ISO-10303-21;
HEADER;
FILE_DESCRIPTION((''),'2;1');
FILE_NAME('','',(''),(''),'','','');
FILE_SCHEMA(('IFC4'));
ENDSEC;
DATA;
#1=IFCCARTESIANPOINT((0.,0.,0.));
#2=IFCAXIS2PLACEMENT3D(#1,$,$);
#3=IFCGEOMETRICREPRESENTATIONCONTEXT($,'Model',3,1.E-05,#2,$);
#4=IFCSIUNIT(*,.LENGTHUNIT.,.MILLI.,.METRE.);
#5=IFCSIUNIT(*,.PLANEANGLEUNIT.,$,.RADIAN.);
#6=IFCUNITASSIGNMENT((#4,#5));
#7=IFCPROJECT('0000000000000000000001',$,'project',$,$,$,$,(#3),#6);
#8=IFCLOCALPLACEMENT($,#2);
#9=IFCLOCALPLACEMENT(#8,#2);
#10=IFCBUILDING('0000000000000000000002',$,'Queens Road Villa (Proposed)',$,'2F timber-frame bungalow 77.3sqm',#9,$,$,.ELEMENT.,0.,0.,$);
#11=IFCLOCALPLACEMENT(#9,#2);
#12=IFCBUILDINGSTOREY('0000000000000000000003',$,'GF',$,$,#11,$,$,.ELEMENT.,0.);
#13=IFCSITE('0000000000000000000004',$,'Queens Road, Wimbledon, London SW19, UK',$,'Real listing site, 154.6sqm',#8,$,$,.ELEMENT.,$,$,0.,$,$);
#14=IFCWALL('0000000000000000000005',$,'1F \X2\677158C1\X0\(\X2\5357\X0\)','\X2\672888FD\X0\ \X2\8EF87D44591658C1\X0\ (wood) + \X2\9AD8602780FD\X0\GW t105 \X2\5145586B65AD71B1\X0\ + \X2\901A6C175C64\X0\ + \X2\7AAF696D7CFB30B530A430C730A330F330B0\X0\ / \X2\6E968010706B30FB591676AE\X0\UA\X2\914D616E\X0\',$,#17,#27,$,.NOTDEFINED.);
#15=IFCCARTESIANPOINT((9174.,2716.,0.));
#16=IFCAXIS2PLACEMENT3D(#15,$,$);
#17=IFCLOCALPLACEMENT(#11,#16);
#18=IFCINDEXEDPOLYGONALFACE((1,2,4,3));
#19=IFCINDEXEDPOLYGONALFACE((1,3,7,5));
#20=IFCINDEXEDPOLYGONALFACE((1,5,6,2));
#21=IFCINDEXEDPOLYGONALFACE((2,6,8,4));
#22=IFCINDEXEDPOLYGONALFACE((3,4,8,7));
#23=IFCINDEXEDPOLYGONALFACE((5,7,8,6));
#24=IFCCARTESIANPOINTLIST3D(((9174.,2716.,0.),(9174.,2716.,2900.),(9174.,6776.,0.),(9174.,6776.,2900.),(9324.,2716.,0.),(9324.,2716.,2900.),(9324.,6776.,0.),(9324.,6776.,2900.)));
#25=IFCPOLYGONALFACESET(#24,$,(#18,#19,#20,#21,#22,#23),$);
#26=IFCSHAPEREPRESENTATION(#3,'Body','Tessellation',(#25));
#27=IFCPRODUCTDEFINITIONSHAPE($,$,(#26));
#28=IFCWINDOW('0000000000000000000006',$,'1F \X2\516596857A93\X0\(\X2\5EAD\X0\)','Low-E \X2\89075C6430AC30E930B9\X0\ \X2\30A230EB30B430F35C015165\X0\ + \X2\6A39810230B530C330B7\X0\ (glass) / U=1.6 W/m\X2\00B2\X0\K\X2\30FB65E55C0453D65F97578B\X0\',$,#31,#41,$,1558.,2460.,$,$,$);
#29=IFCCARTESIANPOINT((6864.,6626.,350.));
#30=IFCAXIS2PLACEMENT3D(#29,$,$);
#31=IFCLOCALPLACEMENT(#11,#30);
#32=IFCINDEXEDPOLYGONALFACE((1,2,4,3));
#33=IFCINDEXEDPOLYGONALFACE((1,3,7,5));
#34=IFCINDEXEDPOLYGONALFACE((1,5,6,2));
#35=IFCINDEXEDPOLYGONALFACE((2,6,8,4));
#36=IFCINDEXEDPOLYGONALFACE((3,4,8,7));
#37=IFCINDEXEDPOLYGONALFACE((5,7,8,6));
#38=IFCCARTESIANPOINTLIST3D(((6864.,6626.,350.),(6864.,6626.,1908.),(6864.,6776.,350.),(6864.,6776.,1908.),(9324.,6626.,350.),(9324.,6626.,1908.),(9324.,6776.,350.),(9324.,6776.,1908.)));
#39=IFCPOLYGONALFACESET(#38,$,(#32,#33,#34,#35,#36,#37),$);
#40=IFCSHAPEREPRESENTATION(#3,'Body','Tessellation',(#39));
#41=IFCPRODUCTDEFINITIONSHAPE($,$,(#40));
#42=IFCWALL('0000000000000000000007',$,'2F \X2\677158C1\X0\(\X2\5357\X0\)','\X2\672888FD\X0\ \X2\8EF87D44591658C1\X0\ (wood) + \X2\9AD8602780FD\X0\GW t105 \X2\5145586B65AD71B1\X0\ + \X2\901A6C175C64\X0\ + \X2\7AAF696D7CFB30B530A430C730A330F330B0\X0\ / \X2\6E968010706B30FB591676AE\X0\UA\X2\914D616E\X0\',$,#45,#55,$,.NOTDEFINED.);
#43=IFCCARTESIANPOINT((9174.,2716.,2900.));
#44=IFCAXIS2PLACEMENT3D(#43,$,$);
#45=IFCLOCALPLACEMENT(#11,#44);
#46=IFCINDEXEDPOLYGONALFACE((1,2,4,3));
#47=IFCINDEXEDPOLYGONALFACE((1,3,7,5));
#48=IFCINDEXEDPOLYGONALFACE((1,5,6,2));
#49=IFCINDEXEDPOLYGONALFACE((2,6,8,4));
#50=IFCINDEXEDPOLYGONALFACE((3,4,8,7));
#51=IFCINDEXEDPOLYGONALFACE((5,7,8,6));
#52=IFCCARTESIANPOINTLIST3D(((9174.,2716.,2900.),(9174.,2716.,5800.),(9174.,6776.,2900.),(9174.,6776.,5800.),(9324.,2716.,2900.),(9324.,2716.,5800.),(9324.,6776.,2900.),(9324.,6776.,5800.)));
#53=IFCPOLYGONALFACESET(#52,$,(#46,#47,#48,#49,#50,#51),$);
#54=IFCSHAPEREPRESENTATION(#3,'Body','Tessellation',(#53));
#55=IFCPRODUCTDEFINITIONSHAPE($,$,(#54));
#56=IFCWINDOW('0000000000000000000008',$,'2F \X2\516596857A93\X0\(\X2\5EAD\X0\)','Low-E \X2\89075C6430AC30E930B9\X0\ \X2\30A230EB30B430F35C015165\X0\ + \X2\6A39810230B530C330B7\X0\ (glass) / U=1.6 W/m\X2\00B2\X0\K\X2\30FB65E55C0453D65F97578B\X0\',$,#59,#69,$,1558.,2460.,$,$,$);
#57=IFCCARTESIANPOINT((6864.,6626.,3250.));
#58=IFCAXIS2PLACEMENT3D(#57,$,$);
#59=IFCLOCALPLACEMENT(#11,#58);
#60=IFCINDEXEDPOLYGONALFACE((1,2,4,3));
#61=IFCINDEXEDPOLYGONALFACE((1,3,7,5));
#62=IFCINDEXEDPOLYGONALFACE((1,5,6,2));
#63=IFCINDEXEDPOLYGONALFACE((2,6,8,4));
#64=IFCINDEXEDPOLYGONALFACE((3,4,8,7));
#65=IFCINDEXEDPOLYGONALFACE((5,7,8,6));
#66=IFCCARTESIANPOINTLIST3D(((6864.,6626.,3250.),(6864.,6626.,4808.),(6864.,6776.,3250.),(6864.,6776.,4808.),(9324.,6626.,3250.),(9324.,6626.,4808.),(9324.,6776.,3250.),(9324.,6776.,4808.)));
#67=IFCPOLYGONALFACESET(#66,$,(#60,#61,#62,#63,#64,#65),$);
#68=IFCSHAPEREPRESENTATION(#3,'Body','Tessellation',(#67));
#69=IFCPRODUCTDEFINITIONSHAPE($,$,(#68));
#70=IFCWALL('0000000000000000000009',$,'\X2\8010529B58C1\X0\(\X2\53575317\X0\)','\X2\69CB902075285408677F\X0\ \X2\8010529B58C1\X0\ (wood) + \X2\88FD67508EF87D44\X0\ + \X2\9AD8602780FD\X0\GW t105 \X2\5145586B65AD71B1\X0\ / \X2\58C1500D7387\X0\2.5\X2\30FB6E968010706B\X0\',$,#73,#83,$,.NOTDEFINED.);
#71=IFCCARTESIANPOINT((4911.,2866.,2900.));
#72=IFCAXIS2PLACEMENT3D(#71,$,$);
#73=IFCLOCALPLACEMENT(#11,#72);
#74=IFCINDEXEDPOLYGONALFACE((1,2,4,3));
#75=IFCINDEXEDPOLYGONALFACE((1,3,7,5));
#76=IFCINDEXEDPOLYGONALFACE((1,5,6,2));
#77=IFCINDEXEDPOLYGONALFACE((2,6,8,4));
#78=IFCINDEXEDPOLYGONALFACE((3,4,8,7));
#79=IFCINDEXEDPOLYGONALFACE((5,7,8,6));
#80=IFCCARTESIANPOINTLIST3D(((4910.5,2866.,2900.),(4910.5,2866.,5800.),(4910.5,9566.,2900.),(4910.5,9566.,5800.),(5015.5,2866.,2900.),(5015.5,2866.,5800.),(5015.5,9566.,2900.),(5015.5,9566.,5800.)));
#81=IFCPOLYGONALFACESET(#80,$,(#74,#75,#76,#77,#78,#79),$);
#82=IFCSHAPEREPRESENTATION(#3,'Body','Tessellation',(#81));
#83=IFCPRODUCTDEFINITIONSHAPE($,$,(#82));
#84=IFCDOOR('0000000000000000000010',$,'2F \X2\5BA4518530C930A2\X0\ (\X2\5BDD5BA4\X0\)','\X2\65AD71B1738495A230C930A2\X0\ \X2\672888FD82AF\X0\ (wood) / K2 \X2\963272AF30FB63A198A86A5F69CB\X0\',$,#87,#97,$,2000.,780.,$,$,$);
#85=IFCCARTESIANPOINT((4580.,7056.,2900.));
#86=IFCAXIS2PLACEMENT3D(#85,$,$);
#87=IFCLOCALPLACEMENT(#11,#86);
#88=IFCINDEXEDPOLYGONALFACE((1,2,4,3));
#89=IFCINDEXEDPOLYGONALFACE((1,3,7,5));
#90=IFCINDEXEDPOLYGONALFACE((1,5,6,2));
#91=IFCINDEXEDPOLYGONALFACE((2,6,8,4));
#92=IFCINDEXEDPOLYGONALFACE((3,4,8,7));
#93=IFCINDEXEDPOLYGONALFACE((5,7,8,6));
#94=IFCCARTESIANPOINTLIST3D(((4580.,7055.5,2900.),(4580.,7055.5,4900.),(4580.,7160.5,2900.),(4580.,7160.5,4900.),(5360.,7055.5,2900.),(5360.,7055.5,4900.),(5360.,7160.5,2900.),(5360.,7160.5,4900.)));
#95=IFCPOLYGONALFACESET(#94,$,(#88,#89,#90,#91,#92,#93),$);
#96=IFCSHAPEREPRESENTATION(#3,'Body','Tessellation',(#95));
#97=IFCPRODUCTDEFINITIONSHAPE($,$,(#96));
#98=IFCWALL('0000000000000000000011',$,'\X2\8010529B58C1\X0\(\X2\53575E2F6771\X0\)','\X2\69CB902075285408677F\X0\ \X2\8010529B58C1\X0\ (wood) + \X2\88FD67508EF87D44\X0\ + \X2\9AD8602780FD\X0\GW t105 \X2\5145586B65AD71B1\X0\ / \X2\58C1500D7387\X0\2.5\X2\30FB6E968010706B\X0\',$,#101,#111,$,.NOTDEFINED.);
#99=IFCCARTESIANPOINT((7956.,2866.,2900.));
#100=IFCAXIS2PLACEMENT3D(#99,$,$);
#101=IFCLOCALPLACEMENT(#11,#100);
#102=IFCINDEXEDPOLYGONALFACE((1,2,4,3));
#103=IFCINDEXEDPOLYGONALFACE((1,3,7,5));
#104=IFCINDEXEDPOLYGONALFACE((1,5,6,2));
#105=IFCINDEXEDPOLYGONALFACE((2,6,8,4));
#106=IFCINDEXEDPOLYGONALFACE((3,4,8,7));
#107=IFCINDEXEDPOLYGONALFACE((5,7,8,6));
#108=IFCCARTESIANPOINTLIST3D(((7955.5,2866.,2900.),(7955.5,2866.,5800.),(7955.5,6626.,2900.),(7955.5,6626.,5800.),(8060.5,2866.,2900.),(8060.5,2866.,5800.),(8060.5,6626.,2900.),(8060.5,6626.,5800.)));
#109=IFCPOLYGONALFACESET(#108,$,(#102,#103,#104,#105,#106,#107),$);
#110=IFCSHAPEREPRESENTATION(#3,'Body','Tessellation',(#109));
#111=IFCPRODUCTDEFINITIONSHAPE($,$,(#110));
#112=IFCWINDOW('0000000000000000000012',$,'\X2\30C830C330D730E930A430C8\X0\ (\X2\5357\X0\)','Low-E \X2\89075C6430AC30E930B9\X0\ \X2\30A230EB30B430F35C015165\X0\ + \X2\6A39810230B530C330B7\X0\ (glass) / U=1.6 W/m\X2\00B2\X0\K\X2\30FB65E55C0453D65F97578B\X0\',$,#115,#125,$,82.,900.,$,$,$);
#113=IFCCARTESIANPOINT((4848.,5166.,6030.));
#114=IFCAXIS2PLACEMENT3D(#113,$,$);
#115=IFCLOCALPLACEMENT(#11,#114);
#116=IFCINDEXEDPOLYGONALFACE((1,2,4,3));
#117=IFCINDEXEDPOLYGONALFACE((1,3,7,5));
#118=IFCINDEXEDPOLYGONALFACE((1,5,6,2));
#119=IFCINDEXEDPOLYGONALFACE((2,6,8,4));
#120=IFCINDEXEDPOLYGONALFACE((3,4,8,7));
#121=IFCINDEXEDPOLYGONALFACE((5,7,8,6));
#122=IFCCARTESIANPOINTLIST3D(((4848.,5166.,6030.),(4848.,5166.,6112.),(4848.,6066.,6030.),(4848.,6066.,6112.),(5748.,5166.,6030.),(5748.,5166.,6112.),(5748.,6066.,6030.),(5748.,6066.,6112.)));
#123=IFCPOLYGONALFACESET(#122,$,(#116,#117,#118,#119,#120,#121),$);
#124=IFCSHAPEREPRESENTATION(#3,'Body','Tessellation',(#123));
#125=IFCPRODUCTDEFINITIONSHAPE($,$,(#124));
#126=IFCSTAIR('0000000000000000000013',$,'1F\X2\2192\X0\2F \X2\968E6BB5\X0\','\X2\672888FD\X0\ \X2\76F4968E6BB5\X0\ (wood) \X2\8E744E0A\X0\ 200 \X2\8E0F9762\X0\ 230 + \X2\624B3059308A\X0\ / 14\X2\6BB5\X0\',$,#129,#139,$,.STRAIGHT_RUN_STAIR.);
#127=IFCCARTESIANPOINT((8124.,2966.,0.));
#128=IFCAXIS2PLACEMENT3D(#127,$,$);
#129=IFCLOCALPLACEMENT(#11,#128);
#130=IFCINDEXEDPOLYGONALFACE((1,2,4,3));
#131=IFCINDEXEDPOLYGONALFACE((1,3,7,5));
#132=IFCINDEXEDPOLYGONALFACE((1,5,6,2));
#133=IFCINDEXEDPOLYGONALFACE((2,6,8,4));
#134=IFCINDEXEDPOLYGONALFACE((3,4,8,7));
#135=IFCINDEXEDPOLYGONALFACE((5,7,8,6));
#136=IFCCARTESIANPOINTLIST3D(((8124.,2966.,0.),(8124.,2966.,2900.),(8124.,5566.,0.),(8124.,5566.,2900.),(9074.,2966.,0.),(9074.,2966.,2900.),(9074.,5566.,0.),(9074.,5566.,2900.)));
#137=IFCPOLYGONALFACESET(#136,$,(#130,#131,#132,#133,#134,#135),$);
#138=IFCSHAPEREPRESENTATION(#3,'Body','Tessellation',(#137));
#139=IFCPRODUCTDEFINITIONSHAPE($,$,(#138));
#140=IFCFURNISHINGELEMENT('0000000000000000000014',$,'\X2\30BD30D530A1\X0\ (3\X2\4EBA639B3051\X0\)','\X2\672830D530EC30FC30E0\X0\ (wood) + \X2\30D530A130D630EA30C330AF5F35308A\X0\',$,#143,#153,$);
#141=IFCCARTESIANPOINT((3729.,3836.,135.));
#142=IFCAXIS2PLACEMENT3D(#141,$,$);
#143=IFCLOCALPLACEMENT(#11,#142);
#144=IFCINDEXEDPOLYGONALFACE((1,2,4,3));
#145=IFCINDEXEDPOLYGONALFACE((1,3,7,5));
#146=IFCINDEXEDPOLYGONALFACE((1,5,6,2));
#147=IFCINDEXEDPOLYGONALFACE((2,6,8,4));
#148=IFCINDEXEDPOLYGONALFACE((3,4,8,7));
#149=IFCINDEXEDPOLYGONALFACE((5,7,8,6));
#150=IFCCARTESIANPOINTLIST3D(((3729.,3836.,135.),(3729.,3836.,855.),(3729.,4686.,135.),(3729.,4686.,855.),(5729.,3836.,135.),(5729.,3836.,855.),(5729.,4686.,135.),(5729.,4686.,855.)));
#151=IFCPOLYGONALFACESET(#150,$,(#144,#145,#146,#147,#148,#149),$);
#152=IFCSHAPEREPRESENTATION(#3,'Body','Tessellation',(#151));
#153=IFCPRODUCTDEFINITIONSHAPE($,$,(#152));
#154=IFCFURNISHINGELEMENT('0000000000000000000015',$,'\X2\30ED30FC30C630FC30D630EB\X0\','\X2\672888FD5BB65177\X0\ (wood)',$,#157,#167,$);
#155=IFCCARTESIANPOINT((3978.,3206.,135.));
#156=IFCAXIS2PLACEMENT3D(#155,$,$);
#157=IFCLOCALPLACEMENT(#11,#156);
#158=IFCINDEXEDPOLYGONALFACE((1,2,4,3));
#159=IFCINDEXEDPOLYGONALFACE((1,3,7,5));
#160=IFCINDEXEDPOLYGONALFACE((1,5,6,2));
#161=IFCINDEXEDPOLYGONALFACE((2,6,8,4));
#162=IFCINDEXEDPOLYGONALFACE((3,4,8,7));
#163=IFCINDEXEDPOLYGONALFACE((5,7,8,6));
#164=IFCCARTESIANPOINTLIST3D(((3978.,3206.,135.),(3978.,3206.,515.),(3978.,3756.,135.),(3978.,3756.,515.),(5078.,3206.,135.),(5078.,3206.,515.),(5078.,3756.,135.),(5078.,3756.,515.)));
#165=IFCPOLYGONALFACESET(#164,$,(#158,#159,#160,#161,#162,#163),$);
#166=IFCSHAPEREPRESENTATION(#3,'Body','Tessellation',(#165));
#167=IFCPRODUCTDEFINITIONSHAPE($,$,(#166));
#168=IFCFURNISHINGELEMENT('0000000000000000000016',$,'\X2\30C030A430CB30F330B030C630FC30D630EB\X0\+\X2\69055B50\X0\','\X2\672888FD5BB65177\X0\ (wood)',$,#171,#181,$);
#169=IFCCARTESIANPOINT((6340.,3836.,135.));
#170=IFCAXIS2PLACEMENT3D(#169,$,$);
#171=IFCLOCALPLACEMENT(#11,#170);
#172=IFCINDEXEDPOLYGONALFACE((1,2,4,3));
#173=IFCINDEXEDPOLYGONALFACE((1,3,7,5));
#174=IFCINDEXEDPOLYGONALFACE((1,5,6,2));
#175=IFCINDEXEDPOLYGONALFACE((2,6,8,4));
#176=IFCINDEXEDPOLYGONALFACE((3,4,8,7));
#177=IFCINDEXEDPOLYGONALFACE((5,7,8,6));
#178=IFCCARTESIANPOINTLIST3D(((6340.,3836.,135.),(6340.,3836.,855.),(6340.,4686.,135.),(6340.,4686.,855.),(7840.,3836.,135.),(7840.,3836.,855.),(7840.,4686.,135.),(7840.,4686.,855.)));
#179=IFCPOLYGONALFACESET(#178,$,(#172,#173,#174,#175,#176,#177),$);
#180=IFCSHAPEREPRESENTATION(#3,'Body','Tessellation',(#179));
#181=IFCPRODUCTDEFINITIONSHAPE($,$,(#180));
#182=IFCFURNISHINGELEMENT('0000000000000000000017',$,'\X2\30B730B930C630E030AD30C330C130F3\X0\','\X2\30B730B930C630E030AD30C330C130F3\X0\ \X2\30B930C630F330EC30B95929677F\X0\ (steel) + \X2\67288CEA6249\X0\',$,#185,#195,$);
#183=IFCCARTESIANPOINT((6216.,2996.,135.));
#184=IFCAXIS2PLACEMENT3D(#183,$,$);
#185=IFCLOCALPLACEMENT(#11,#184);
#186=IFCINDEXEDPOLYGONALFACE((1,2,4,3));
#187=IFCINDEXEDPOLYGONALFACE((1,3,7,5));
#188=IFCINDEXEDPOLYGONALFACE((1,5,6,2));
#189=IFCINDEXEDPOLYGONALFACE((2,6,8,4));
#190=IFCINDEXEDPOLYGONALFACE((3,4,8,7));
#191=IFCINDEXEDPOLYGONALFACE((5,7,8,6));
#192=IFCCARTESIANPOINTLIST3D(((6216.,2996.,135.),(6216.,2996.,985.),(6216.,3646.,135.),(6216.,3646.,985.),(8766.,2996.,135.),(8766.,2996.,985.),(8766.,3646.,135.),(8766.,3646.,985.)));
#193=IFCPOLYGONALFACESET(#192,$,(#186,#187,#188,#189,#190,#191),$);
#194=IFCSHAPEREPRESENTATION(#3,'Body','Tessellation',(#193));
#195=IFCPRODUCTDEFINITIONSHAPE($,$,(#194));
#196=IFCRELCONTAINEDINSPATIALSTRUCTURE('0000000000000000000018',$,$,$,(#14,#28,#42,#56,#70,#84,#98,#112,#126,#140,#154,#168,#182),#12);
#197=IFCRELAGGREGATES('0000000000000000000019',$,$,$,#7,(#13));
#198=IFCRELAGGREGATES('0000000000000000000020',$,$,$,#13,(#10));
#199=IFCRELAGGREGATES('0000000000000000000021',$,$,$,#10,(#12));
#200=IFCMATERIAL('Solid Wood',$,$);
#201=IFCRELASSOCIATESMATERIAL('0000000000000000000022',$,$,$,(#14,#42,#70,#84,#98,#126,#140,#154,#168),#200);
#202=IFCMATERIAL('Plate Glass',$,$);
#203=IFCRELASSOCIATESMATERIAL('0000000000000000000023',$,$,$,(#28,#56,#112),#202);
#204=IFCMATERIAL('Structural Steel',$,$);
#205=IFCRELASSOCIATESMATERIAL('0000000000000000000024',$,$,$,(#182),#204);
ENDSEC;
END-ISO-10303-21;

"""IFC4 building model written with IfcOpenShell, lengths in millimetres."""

from ifc_helpers import new_model, si_unit, frame, frame_2d, origin, place, context, project, spatial, rectangle, extrude, material, element, fill, save


model = new_model("IFC4")

# Units and contexts
model_context = context("Model", 3, precision=1e-05, world=origin())
ifc_project = project(units=[si_unit("LENGTHUNIT", "METRE", prefix="MILLI"), si_unit("PLANEANGLEUNIT", "RADIAN")], contexts=[model_context])

# Site, building, storey
site_placement = place(None, origin())
site = spatial("IfcSite", under=ifc_project, at=site_placement, Name="Queens Road, Wimbledon, London SW19, UK", ObjectType="Real listing site, 154.6sqm", CompositionType="ELEMENT", RefElevation=0.0)
building_placement = place(site_placement, origin())
building = spatial("IfcBuilding", under=site, at=building_placement, Name="Queens Road Villa (Proposed)", ObjectType="2F timber-frame bungalow 77.3sqm", CompositionType="ELEMENT", ElevationOfRefHeight=0.0, ElevationOfTerrain=0.0)
storey_placement = place(building_placement, origin())
storey = spatial("IfcBuildingStorey", under=building, at=storey_placement, Name="GF", CompositionType="ELEMENT", Elevation=0.0)

# Wall, opening, window
ifc_material_1 = material(Name="Solid Wood")
wall_1_placement = place(storey_placement, frame((9174.0, 2716.0, 0.0)))
wall_1 = element("IfcWall", 1, at=wall_1_placement, inside=storey, material=ifc_material_1, Name="1F 東壁(南)", Description="木製 軸組外壁 (wood) + 高性能GW t105 充填断熱 + 通気層 + 窯業系サイディング / 準耐火・外皮UA配慮", PredefinedType="NOTDEFINED", context=model_context, shape_type="SweptSolid", body=[
    extrude(rectangle(XDim=150.0, YDim=4060.0, at=frame_2d((75.0, 2030.0))), frame((9174.0, 2716.0, 0.0)), (0.0, 0.0, 1.0), 2900.0),
])
opening_1_placement = place(storey_placement, frame((6864.0, 6626.0, 350.0)))
opening_1 = element("IfcOpeningElement", 2, at=opening_1_placement, cuts=wall_1, PredefinedType="NOTDEFINED", context=model_context, shape_type="SweptSolid", body=[
    extrude(rectangle(XDim=2460.0, YDim=150.0, at=frame_2d((1230.0, 75.0))), frame((6864.0, 6626.0, 350.0)), (0.0, 0.0, 1.0), 1558.0),
])
ifc_material_2 = material(Name="Plate Glass")
window_1_placement = place(storey_placement, frame((6864.0, 6626.0, 350.0)))
window_1 = element("IfcWindow", 3, at=window_1_placement, inside=storey, material=ifc_material_2, Name="1F 入隅窓(庭)", Description="Low-E 複層ガラス アルゴン封入 + 樹脂サッシ (glass) / U=1.6 W/m²K・日射取得型", OverallHeight=1558.0, OverallWidth=2460.0, context=model_context, shape_type="SweptSolid", body=[
    extrude(rectangle(XDim=2460.0, YDim=150.0, at=frame_2d((1230.0, 75.0))), frame((6864.0, 6626.0, 350.0)), (0.0, 0.0, 1.0), 1558.0),
])
fill(opening_1, window_1)

# Wall, opening, window
wall_2_placement = place(storey_placement, frame((9174.0, 2716.0, 2900.0)))
wall_2 = element("IfcWall", 4, at=wall_2_placement, inside=storey, material=ifc_material_1, Name="2F 東壁(南)", Description="木製 軸組外壁 (wood) + 高性能GW t105 充填断熱 + 通気層 + 窯業系サイディング / 準耐火・外皮UA配慮", PredefinedType="NOTDEFINED", context=model_context, shape_type="SweptSolid", body=[
    extrude(rectangle(XDim=150.0, YDim=4060.0, at=frame_2d((75.0, 2030.0))), frame((9174.0, 2716.0, 2900.0)), (0.0, 0.0, 1.0), 2900.0),
])
opening_2_placement = place(storey_placement, frame((6864.0, 6626.0, 3250.0)))
opening_2 = element("IfcOpeningElement", 5, at=opening_2_placement, cuts=wall_2, PredefinedType="NOTDEFINED", context=model_context, shape_type="SweptSolid", body=[
    extrude(rectangle(XDim=2460.0, YDim=150.0, at=frame_2d((1230.0, 75.0))), frame((6864.0, 6626.0, 3250.0)), (0.0, 0.0, 1.0), 1558.0),
])
window_2_placement = place(storey_placement, frame((6864.0, 6626.0, 3250.0)))
window_2 = element("IfcWindow", 6, at=window_2_placement, inside=storey, material=ifc_material_2, Name="2F 入隅窓(庭)", Description="Low-E 複層ガラス アルゴン封入 + 樹脂サッシ (glass) / U=1.6 W/m²K・日射取得型", OverallHeight=1558.0, OverallWidth=2460.0, context=model_context, shape_type="SweptSolid", body=[
    extrude(rectangle(XDim=2460.0, YDim=150.0, at=frame_2d((1230.0, 75.0))), frame((6864.0, 6626.0, 3250.0)), (0.0, 0.0, 1.0), 1558.0),
])
fill(opening_2, window_2)

# Wall, opening, door
wall_3_placement = place(storey_placement, frame((4911.0, 2866.0, 2900.0)))
wall_3 = element("IfcWall", 7, at=wall_3_placement, inside=storey, material=ifc_material_1, Name="耐力壁(南北)", Description="構造用合板 耐力壁 (wood) + 製材軸組 + 高性能GW t105 充填断熱 / 壁倍率2.5・準耐火", PredefinedType="NOTDEFINED", context=model_context, shape_type="SweptSolid", body=[
    extrude(rectangle(XDim=105.0, YDim=6700.0, at=frame_2d((52.0, 3350.0))), frame((4911.0, 2866.0, 2900.0)), (0.0, 0.0, 1.0), 2900.0),
])
opening_3_placement = place(storey_placement, frame((4580.0, 7056.0, 2900.0)))
opening_3 = element("IfcOpeningElement", 8, at=opening_3_placement, cuts=wall_3, PredefinedType="NOTDEFINED", context=model_context, shape_type="SweptSolid", body=[
    extrude(rectangle(XDim=780.0, YDim=105.0, at=frame_2d((390.0, 52.0))), frame((4580.0, 7056.0, 2900.0)), (0.0, 0.0, 1.0), 2000.0),
])
door_1_placement = place(storey_placement, frame((4580.0, 7056.0, 2900.0)))
door_1 = element("IfcDoor", 9, at=door_1_placement, inside=storey, material=ifc_material_1, Name="2F 室内ドア (寝室)", Description="断熱玄関ドア 木製芯 (wood) / K2 防犯・採風機構", OverallHeight=2000.0, OverallWidth=780.0, context=model_context, shape_type="SweptSolid", body=[
    extrude(rectangle(XDim=780.0, YDim=105.0, at=frame_2d((390.0, 52.0))), frame((4580.0, 7056.0, 2900.0)), (0.0, 0.0, 1.0), 2000.0),
])
fill(opening_3, door_1)

# Wall
wall_4_placement = place(storey_placement, frame((7956.0, 2866.0, 2900.0)))
element("IfcWall", 10, at=wall_4_placement, inside=storey, material=ifc_material_1, Name="耐力壁(南帯東)", Description="構造用合板 耐力壁 (wood) + 製材軸組 + 高性能GW t105 充填断熱 / 壁倍率2.5・準耐火", PredefinedType="NOTDEFINED", context=model_context, shape_type="SweptSolid", body=[
    extrude(rectangle(XDim=105.0, YDim=3760.0, at=frame_2d((52.0, 1880.0))), frame((7956.0, 2866.0, 2900.0)), (0.0, 0.0, 1.0), 2900.0),
])

# Window
window_3_placement = place(storey_placement, frame((4848.0, 5166.0, 6030.0)))
element("IfcWindow", 11, at=window_3_placement, inside=storey, material=ifc_material_2, Name="トップライト (南)", Description="Low-E 複層ガラス アルゴン封入 + 樹脂サッシ (glass) / U=1.6 W/m²K・日射取得型", OverallHeight=82.0, OverallWidth=900.0, context=model_context, shape_type="SweptSolid", body=[
    extrude(rectangle(XDim=900.0, YDim=900.0, at=frame_2d((450.0, 450.0))), frame((4848.0, 5166.0, 6030.0)), (0.0, 0.0, 1.0), 82.0),
])

# Stair
stair_placement = place(storey_placement, frame((8124.0, 2966.0, 0.0)))
element("IfcStair", 12, at=stair_placement, inside=storey, material=ifc_material_1, Name="1F→2F 階段", Description="木製 直階段 (wood) 蹴上 200 踏面 230 + 手すり / 14段", PredefinedType="STRAIGHT_RUN_STAIR", context=model_context, shape_type="SweptSolid", body=[
    extrude(rectangle(XDim=950.0, YDim=2600.0, at=frame_2d((475.0, 1300.0))), frame((8124.0, 2966.0, 0.0)), (0.0, 0.0, 1.0), 2900.0),
])

# Furnishing elements
furnishing_1_placement = place(storey_placement, frame((3729.0, 3836.0, 135.0)))
element("IfcFurnishingElement", 13, at=furnishing_1_placement, inside=storey, material=ifc_material_1, Name="ソファ (3人掛け)", Description="木フレーム (wood) + ファブリック張り", context=model_context, shape_type="SweptSolid", body=[
    extrude(rectangle(XDim=2000.0, YDim=850.0, at=frame_2d((1000.0, 425.0))), frame((3729.0, 3836.0, 135.0)), (0.0, 0.0, 1.0), 720.0),
])
furnishing_2_placement = place(storey_placement, frame((3978.0, 3206.0, 135.0)))
element("IfcFurnishingElement", 14, at=furnishing_2_placement, inside=storey, material=ifc_material_1, Name="ローテーブル", Description="木製家具 (wood)", context=model_context, shape_type="SweptSolid", body=[
    extrude(rectangle(XDim=1100.0, YDim=550.0, at=frame_2d((550.0, 275.0))), frame((3978.0, 3206.0, 135.0)), (0.0, 0.0, 1.0), 380.0),
])
furnishing_3_placement = place(storey_placement, frame((6340.0, 3836.0, 135.0)))
element("IfcFurnishingElement", 15, at=furnishing_3_placement, inside=storey, material=ifc_material_1, Name="ダイニングテーブル+椅子", Description="木製家具 (wood)", context=model_context, shape_type="SweptSolid", body=[
    extrude(rectangle(XDim=1500.0, YDim=850.0, at=frame_2d((750.0, 425.0))), frame((6340.0, 3836.0, 135.0)), (0.0, 0.0, 1.0), 720.0),
])
ifc_material_3 = material(Name="Structural Steel")
furnishing_4_placement = place(storey_placement, frame((6216.0, 2996.0, 135.0)))
element("IfcFurnishingElement", 16, at=furnishing_4_placement, inside=storey, material=ifc_material_3, Name="システムキッチン", Description="システムキッチン ステンレス天板 (steel) + 木質扉", context=model_context, shape_type="SweptSolid", body=[
    extrude(rectangle(XDim=2550.0, YDim=650.0, at=frame_2d((1275.0, 325.0))), frame((6216.0, 2996.0, 135.0)), (0.0, 0.0, 1.0), 850.0),
])

save(model, "model.ifc")
